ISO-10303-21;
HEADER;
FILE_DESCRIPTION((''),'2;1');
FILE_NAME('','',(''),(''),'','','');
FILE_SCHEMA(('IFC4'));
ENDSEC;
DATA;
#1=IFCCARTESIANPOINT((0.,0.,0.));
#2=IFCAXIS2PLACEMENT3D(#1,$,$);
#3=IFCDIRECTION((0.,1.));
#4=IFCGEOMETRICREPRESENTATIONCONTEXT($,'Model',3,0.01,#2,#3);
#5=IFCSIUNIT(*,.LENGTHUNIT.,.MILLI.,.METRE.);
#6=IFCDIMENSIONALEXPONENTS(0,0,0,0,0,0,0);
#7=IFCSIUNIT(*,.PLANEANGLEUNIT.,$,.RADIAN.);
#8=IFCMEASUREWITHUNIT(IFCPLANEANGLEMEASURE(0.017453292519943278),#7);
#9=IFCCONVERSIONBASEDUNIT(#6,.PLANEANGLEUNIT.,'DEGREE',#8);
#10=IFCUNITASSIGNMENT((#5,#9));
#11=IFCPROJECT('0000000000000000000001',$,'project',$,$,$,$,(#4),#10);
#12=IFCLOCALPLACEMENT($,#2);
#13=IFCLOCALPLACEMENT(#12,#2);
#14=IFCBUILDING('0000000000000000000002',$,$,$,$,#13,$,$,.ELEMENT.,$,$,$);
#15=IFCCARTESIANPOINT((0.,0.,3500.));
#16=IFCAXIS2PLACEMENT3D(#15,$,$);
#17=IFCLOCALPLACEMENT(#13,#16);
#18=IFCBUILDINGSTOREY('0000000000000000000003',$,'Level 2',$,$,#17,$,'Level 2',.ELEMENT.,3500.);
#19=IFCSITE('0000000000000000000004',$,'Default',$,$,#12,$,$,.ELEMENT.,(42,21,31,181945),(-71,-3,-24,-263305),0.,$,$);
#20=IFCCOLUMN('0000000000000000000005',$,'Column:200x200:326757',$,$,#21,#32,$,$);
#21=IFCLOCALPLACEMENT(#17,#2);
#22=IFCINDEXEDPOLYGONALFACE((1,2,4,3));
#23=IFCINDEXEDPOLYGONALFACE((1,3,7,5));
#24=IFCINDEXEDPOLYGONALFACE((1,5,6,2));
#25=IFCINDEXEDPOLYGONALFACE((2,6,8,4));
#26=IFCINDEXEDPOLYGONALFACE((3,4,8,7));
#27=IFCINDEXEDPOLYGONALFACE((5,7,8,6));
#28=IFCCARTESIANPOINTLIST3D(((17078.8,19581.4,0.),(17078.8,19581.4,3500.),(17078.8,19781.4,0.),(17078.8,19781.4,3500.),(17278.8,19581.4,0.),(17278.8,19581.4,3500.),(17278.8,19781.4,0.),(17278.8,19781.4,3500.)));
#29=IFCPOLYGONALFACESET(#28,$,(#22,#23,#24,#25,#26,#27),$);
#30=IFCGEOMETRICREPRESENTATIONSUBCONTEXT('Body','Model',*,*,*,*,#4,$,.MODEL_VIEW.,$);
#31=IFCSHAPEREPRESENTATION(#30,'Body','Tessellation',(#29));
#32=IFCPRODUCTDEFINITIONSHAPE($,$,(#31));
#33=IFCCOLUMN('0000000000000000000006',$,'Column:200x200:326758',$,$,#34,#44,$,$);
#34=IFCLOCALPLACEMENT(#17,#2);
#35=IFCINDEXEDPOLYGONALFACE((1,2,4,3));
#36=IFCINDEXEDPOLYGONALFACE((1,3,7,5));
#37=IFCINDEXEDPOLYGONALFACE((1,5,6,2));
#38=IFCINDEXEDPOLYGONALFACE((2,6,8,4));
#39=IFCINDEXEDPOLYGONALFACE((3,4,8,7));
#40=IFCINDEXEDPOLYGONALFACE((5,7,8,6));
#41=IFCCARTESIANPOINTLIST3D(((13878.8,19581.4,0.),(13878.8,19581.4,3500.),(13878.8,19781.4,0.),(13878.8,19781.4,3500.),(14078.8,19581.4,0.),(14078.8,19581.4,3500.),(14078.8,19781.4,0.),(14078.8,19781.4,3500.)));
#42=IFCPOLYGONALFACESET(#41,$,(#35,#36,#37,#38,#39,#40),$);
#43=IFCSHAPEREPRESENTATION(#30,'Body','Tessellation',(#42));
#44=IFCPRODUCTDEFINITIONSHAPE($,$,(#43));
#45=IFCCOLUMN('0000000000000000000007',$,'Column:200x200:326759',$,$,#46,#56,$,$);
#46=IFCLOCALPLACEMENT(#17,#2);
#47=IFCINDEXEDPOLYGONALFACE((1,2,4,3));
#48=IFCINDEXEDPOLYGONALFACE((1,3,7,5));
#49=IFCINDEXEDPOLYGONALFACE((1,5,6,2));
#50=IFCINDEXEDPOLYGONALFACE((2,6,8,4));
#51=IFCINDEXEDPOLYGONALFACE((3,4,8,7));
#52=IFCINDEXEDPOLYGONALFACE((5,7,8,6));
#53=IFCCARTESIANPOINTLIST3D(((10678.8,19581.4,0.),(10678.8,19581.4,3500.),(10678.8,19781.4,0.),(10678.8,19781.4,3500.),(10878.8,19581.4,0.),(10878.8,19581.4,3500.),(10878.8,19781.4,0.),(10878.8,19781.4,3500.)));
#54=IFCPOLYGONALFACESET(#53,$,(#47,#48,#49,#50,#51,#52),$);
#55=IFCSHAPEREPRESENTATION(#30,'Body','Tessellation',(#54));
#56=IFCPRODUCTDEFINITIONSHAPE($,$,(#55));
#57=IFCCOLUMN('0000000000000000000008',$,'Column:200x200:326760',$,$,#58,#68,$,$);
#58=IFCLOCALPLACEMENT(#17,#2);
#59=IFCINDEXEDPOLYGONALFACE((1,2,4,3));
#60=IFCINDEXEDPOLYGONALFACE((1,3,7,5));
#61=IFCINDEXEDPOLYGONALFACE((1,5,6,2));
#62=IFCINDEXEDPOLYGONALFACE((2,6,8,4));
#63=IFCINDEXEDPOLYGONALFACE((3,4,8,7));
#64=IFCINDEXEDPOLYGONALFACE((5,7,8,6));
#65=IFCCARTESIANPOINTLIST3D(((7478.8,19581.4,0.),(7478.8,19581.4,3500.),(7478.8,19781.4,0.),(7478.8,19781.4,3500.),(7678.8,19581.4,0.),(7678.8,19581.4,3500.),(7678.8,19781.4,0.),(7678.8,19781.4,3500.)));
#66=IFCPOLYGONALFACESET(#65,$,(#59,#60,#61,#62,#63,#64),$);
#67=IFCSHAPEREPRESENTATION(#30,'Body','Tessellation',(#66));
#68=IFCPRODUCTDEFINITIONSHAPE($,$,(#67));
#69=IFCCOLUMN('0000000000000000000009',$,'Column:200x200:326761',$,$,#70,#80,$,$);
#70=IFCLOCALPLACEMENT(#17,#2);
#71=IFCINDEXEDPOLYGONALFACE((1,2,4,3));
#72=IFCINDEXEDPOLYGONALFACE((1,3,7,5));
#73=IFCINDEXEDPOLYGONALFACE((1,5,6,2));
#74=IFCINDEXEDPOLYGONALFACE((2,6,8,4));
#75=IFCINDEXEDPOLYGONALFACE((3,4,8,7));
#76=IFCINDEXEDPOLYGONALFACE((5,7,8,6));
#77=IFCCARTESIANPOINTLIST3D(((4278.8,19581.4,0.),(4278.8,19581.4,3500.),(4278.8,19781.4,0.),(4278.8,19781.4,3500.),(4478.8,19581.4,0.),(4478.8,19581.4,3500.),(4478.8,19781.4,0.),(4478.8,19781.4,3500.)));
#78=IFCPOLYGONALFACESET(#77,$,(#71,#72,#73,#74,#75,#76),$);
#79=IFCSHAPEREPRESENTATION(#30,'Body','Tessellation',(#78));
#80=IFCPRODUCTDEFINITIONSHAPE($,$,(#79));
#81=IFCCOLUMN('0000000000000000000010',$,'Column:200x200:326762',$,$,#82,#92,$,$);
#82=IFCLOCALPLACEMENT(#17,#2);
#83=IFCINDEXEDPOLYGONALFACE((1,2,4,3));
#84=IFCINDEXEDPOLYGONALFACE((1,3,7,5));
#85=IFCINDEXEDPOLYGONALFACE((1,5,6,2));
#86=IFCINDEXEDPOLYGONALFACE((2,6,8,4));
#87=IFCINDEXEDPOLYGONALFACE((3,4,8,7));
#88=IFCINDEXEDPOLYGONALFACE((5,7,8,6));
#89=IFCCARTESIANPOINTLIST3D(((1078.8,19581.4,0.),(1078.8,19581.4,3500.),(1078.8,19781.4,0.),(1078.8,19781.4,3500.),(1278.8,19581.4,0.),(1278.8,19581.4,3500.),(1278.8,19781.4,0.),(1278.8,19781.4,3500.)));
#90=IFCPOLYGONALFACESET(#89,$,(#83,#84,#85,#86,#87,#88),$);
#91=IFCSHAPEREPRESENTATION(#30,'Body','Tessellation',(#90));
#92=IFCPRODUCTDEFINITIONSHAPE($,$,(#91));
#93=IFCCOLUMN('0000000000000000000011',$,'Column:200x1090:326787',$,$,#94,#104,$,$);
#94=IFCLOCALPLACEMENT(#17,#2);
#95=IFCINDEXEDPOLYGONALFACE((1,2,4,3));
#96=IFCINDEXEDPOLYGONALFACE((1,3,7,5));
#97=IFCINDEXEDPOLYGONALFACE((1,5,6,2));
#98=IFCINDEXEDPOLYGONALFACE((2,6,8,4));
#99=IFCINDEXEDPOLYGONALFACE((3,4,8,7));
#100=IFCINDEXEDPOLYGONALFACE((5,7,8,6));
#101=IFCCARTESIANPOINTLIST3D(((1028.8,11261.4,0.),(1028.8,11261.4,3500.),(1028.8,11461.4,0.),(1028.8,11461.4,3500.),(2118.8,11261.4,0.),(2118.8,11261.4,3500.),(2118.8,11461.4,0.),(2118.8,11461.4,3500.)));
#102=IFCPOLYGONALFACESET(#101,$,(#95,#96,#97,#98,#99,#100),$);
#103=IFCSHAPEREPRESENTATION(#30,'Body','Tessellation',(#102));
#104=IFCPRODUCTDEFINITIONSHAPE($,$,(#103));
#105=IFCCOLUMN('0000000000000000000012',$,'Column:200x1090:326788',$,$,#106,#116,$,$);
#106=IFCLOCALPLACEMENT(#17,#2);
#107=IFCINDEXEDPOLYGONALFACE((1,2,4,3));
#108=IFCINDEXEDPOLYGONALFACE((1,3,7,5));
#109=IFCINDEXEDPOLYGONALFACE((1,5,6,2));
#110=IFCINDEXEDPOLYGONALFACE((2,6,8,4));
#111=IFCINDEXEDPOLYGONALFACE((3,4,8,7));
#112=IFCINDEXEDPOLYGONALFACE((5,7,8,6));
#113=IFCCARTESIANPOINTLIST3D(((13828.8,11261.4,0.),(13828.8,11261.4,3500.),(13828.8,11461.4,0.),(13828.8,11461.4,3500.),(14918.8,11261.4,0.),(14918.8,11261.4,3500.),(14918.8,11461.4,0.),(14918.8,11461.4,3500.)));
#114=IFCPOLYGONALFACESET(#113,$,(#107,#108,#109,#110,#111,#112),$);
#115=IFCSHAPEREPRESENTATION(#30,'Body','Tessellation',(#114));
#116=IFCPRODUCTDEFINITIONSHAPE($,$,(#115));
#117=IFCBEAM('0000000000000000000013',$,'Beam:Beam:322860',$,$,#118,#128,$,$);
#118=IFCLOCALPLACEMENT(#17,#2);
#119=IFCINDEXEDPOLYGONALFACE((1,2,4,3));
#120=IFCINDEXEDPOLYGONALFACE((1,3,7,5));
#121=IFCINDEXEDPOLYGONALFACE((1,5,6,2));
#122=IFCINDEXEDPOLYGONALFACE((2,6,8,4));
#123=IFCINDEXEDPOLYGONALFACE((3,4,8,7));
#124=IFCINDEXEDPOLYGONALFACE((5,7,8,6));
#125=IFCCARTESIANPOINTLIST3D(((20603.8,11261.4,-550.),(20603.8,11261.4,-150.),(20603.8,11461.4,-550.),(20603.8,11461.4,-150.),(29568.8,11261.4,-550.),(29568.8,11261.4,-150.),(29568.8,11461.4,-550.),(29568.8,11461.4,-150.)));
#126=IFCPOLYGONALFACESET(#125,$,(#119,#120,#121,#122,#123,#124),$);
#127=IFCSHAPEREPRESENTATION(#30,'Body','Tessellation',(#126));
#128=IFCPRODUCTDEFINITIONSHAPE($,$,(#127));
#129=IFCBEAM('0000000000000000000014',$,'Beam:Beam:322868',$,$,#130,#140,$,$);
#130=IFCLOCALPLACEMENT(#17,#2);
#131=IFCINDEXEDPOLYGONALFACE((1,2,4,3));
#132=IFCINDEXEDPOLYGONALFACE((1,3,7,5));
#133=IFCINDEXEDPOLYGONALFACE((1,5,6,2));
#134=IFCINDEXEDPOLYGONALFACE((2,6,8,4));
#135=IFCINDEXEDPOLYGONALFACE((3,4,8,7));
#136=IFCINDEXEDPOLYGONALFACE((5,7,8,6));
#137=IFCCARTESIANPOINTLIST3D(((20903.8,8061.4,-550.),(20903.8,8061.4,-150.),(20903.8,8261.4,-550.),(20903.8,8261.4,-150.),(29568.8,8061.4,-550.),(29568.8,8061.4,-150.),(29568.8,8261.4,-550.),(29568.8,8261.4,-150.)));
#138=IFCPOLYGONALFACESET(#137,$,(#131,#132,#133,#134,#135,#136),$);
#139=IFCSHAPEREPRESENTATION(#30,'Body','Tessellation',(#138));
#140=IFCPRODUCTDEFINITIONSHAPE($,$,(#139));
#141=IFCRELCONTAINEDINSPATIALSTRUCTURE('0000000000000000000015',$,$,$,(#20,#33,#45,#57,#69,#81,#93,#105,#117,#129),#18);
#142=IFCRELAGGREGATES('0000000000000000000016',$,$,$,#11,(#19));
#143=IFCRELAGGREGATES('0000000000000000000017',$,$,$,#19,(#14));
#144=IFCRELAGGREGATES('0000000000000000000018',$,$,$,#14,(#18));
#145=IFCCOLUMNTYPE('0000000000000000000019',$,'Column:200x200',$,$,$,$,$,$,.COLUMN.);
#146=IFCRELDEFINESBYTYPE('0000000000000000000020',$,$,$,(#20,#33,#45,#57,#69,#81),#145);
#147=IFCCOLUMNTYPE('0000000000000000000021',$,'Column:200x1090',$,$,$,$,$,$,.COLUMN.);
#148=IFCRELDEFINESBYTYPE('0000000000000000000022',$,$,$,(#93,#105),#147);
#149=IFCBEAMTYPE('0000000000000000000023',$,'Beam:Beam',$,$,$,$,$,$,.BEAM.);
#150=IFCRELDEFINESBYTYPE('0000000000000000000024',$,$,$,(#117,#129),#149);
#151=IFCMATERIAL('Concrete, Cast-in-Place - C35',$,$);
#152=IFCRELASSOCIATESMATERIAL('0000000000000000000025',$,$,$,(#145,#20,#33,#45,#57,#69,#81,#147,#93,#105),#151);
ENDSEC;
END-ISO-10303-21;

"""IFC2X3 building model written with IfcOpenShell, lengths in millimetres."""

from ifc_helpers import new_model, entity, si_unit, converted_unit, direction, frame, frame_2d, origin, origin_2d_with_axis, place, context, subcontext, project, spatial, rectangle, extrude, source, transform, mapped, material, type_object, type_shapes, element, save


model = new_model("IFC2X3")

# Units and contexts
model_context = context("Model", 3, precision=0.01, world=origin(), true_north=direction((0.0, 1.0)))
body_context = subcontext(model_context, "Body", "Model", "MODEL_VIEW")
ifc_project = project(units=[si_unit("LENGTHUNIT", "METRE", prefix="MILLI"), converted_unit("PLANEANGLEUNIT", "DEGREE", entity("IfcPlaneAngleMeasure", 0.017453292519943278), si_unit("PLANEANGLEUNIT", "RADIAN"), dimensions=[0, 0, 0, 0, 0, 0, 0])], contexts=[model_context])

# Site, building, storey
site_placement = place(None, origin())
site = spatial("IfcSite", under=ifc_project, at=site_placement, Name="Default", CompositionType="ELEMENT", RefLatitude=(42, 21, 31, 181945), RefLongitude=(-71, -3, -24, -263305), RefElevation=0.0)
building_placement = place(site_placement, origin())
building = spatial("IfcBuilding", under=site, at=building_placement, CompositionType="ELEMENT")
storey_placement = place(building_placement, frame((0.0, 0.0, 3500.0)))
storey = spatial("IfcBuildingStorey", under=building, at=storey_placement, Name="Level 2", LongName="Level 2", CompositionType="ELEMENT", Elevation=3500.0)

# Columns
ifc_material = material(Name="Concrete, Cast-in-Place - C35")
column_type_1 = type_object("IfcColumnType", Name="Column:200x200", PredefinedType="COLUMN", material=ifc_material)
shared_shape_1 = source(origin(), body_context, "Body", "SweptSolid", [
    extrude(rectangle(XDim=200.0, YDim=200.0, at=frame_2d((0.0, 0.0), x_axis=(1.0, 0.0))), frame((0.0, 0.0, 3500.0), z_axis=(0.0, 0.0, 1.0), x_axis=(-1.0, 0.0, 0.0)), (0.0, 0.0, 1.0), 3500.0),
])
type_shapes(column_type_1, [shared_shape_1])
for number, where, name in (
    (1, (17178.8, 19681.4, -3500.0), "Column:200x200:326757"),
    (2, (13978.8, 19681.4, -3500.0), "Column:200x200:326758"),
    (3, (10778.8, 19681.4, -3500.0), "Column:200x200:326759"),
    (4, (7578.8, 19681.4, -3500.0), "Column:200x200:326760"),
    (5, (4378.8, 19681.4, -3500.0), "Column:200x200:326761"),
    (6, (1178.8, 19681.4, -3500.0), "Column:200x200:326762"),
):
    element("IfcColumn", number, at=place(storey_placement, frame(where)), inside=storey, type_object=column_type_1, material=ifc_material, Name=name, context=body_context, shape_type="MappedRepresentation", body=[
        mapped(shared_shape_1, transform((0.0, 0.0, 0.0), scale=1.0)),
    ])
column_type_2 = type_object("IfcColumnType", Name="Column:200x1090", PredefinedType="COLUMN", material=ifc_material)
shared_shape_2 = source(origin(), body_context, "Body", "SweptSolid", [
    extrude(rectangle(XDim=1090.0, YDim=200.0, at=origin_2d_with_axis()), frame((-445.0, 0.0, 3500.0), z_axis=(0.0, 0.0, 1.0), x_axis=(-1.0, 0.0, 0.0)), (0.0, 0.0, 1.0), 3500.0),
])
type_shapes(column_type_2, [shared_shape_2])
for number, where, name in (
    (7, (2018.8, 11361.4, -3500.0), "Column:200x1090:326787"),
    (8, (14818.8, 11361.4, -3500.0), "Column:200x1090:326788"),
):
    element("IfcColumn", number, at=place(storey_placement, frame(where)), inside=storey, type_object=column_type_2, material=ifc_material, Name=name, context=body_context, shape_type="MappedRepresentation", body=[
        mapped(shared_shape_2, transform((0.0, 0.0, 0.0), scale=1.0)),
    ])

# Beams
beam_type = type_object("IfcBeamType", Name="Beam:Beam", PredefinedType="BEAM")
beam_1_placement = place(storey_placement, frame((29568.8, 11386.4, -150.0), z_axis=(0.0, 0.0, 1.0), x_axis=(-1.0, 0.0, 0.0)))
element("IfcBeam", 9, at=beam_1_placement, inside=storey, type_object=beam_type, Name="Beam:Beam:322860", context=body_context, shape_type="SweptSolid", body=[
    extrude(rectangle(XDim=400.0, YDim=200.0, at=origin_2d_with_axis()), frame((0.0, 25.0, -200.0), z_axis=(1.0, 0.0, 0.0), x_axis=(0.0, 0.0, -1.0)), (0.0, 0.0, 1.0), 8965.0),
])
beam_2_placement = place(storey_placement, frame((29568.8, 8186.4, -150.0), z_axis=(0.0, 0.0, 1.0), x_axis=(-1.0, 0.0, 0.0)))
element("IfcBeam", 10, at=beam_2_placement, inside=storey, type_object=beam_type, Name="Beam:Beam:322868", context=body_context, shape_type="SweptSolid", body=[
    extrude(rectangle(XDim=400.0, YDim=200.0, at=frame_2d((0.0, 0.0), x_axis=(1.0, 0.0))), frame((0.0, 25.0, -200.0), z_axis=(1.0, 0.0, 0.0), x_axis=(0.0, 0.0, -1.0)), (0.0, 0.0, 1.0), 8665.0),
])

save(model, "model.ifc")
